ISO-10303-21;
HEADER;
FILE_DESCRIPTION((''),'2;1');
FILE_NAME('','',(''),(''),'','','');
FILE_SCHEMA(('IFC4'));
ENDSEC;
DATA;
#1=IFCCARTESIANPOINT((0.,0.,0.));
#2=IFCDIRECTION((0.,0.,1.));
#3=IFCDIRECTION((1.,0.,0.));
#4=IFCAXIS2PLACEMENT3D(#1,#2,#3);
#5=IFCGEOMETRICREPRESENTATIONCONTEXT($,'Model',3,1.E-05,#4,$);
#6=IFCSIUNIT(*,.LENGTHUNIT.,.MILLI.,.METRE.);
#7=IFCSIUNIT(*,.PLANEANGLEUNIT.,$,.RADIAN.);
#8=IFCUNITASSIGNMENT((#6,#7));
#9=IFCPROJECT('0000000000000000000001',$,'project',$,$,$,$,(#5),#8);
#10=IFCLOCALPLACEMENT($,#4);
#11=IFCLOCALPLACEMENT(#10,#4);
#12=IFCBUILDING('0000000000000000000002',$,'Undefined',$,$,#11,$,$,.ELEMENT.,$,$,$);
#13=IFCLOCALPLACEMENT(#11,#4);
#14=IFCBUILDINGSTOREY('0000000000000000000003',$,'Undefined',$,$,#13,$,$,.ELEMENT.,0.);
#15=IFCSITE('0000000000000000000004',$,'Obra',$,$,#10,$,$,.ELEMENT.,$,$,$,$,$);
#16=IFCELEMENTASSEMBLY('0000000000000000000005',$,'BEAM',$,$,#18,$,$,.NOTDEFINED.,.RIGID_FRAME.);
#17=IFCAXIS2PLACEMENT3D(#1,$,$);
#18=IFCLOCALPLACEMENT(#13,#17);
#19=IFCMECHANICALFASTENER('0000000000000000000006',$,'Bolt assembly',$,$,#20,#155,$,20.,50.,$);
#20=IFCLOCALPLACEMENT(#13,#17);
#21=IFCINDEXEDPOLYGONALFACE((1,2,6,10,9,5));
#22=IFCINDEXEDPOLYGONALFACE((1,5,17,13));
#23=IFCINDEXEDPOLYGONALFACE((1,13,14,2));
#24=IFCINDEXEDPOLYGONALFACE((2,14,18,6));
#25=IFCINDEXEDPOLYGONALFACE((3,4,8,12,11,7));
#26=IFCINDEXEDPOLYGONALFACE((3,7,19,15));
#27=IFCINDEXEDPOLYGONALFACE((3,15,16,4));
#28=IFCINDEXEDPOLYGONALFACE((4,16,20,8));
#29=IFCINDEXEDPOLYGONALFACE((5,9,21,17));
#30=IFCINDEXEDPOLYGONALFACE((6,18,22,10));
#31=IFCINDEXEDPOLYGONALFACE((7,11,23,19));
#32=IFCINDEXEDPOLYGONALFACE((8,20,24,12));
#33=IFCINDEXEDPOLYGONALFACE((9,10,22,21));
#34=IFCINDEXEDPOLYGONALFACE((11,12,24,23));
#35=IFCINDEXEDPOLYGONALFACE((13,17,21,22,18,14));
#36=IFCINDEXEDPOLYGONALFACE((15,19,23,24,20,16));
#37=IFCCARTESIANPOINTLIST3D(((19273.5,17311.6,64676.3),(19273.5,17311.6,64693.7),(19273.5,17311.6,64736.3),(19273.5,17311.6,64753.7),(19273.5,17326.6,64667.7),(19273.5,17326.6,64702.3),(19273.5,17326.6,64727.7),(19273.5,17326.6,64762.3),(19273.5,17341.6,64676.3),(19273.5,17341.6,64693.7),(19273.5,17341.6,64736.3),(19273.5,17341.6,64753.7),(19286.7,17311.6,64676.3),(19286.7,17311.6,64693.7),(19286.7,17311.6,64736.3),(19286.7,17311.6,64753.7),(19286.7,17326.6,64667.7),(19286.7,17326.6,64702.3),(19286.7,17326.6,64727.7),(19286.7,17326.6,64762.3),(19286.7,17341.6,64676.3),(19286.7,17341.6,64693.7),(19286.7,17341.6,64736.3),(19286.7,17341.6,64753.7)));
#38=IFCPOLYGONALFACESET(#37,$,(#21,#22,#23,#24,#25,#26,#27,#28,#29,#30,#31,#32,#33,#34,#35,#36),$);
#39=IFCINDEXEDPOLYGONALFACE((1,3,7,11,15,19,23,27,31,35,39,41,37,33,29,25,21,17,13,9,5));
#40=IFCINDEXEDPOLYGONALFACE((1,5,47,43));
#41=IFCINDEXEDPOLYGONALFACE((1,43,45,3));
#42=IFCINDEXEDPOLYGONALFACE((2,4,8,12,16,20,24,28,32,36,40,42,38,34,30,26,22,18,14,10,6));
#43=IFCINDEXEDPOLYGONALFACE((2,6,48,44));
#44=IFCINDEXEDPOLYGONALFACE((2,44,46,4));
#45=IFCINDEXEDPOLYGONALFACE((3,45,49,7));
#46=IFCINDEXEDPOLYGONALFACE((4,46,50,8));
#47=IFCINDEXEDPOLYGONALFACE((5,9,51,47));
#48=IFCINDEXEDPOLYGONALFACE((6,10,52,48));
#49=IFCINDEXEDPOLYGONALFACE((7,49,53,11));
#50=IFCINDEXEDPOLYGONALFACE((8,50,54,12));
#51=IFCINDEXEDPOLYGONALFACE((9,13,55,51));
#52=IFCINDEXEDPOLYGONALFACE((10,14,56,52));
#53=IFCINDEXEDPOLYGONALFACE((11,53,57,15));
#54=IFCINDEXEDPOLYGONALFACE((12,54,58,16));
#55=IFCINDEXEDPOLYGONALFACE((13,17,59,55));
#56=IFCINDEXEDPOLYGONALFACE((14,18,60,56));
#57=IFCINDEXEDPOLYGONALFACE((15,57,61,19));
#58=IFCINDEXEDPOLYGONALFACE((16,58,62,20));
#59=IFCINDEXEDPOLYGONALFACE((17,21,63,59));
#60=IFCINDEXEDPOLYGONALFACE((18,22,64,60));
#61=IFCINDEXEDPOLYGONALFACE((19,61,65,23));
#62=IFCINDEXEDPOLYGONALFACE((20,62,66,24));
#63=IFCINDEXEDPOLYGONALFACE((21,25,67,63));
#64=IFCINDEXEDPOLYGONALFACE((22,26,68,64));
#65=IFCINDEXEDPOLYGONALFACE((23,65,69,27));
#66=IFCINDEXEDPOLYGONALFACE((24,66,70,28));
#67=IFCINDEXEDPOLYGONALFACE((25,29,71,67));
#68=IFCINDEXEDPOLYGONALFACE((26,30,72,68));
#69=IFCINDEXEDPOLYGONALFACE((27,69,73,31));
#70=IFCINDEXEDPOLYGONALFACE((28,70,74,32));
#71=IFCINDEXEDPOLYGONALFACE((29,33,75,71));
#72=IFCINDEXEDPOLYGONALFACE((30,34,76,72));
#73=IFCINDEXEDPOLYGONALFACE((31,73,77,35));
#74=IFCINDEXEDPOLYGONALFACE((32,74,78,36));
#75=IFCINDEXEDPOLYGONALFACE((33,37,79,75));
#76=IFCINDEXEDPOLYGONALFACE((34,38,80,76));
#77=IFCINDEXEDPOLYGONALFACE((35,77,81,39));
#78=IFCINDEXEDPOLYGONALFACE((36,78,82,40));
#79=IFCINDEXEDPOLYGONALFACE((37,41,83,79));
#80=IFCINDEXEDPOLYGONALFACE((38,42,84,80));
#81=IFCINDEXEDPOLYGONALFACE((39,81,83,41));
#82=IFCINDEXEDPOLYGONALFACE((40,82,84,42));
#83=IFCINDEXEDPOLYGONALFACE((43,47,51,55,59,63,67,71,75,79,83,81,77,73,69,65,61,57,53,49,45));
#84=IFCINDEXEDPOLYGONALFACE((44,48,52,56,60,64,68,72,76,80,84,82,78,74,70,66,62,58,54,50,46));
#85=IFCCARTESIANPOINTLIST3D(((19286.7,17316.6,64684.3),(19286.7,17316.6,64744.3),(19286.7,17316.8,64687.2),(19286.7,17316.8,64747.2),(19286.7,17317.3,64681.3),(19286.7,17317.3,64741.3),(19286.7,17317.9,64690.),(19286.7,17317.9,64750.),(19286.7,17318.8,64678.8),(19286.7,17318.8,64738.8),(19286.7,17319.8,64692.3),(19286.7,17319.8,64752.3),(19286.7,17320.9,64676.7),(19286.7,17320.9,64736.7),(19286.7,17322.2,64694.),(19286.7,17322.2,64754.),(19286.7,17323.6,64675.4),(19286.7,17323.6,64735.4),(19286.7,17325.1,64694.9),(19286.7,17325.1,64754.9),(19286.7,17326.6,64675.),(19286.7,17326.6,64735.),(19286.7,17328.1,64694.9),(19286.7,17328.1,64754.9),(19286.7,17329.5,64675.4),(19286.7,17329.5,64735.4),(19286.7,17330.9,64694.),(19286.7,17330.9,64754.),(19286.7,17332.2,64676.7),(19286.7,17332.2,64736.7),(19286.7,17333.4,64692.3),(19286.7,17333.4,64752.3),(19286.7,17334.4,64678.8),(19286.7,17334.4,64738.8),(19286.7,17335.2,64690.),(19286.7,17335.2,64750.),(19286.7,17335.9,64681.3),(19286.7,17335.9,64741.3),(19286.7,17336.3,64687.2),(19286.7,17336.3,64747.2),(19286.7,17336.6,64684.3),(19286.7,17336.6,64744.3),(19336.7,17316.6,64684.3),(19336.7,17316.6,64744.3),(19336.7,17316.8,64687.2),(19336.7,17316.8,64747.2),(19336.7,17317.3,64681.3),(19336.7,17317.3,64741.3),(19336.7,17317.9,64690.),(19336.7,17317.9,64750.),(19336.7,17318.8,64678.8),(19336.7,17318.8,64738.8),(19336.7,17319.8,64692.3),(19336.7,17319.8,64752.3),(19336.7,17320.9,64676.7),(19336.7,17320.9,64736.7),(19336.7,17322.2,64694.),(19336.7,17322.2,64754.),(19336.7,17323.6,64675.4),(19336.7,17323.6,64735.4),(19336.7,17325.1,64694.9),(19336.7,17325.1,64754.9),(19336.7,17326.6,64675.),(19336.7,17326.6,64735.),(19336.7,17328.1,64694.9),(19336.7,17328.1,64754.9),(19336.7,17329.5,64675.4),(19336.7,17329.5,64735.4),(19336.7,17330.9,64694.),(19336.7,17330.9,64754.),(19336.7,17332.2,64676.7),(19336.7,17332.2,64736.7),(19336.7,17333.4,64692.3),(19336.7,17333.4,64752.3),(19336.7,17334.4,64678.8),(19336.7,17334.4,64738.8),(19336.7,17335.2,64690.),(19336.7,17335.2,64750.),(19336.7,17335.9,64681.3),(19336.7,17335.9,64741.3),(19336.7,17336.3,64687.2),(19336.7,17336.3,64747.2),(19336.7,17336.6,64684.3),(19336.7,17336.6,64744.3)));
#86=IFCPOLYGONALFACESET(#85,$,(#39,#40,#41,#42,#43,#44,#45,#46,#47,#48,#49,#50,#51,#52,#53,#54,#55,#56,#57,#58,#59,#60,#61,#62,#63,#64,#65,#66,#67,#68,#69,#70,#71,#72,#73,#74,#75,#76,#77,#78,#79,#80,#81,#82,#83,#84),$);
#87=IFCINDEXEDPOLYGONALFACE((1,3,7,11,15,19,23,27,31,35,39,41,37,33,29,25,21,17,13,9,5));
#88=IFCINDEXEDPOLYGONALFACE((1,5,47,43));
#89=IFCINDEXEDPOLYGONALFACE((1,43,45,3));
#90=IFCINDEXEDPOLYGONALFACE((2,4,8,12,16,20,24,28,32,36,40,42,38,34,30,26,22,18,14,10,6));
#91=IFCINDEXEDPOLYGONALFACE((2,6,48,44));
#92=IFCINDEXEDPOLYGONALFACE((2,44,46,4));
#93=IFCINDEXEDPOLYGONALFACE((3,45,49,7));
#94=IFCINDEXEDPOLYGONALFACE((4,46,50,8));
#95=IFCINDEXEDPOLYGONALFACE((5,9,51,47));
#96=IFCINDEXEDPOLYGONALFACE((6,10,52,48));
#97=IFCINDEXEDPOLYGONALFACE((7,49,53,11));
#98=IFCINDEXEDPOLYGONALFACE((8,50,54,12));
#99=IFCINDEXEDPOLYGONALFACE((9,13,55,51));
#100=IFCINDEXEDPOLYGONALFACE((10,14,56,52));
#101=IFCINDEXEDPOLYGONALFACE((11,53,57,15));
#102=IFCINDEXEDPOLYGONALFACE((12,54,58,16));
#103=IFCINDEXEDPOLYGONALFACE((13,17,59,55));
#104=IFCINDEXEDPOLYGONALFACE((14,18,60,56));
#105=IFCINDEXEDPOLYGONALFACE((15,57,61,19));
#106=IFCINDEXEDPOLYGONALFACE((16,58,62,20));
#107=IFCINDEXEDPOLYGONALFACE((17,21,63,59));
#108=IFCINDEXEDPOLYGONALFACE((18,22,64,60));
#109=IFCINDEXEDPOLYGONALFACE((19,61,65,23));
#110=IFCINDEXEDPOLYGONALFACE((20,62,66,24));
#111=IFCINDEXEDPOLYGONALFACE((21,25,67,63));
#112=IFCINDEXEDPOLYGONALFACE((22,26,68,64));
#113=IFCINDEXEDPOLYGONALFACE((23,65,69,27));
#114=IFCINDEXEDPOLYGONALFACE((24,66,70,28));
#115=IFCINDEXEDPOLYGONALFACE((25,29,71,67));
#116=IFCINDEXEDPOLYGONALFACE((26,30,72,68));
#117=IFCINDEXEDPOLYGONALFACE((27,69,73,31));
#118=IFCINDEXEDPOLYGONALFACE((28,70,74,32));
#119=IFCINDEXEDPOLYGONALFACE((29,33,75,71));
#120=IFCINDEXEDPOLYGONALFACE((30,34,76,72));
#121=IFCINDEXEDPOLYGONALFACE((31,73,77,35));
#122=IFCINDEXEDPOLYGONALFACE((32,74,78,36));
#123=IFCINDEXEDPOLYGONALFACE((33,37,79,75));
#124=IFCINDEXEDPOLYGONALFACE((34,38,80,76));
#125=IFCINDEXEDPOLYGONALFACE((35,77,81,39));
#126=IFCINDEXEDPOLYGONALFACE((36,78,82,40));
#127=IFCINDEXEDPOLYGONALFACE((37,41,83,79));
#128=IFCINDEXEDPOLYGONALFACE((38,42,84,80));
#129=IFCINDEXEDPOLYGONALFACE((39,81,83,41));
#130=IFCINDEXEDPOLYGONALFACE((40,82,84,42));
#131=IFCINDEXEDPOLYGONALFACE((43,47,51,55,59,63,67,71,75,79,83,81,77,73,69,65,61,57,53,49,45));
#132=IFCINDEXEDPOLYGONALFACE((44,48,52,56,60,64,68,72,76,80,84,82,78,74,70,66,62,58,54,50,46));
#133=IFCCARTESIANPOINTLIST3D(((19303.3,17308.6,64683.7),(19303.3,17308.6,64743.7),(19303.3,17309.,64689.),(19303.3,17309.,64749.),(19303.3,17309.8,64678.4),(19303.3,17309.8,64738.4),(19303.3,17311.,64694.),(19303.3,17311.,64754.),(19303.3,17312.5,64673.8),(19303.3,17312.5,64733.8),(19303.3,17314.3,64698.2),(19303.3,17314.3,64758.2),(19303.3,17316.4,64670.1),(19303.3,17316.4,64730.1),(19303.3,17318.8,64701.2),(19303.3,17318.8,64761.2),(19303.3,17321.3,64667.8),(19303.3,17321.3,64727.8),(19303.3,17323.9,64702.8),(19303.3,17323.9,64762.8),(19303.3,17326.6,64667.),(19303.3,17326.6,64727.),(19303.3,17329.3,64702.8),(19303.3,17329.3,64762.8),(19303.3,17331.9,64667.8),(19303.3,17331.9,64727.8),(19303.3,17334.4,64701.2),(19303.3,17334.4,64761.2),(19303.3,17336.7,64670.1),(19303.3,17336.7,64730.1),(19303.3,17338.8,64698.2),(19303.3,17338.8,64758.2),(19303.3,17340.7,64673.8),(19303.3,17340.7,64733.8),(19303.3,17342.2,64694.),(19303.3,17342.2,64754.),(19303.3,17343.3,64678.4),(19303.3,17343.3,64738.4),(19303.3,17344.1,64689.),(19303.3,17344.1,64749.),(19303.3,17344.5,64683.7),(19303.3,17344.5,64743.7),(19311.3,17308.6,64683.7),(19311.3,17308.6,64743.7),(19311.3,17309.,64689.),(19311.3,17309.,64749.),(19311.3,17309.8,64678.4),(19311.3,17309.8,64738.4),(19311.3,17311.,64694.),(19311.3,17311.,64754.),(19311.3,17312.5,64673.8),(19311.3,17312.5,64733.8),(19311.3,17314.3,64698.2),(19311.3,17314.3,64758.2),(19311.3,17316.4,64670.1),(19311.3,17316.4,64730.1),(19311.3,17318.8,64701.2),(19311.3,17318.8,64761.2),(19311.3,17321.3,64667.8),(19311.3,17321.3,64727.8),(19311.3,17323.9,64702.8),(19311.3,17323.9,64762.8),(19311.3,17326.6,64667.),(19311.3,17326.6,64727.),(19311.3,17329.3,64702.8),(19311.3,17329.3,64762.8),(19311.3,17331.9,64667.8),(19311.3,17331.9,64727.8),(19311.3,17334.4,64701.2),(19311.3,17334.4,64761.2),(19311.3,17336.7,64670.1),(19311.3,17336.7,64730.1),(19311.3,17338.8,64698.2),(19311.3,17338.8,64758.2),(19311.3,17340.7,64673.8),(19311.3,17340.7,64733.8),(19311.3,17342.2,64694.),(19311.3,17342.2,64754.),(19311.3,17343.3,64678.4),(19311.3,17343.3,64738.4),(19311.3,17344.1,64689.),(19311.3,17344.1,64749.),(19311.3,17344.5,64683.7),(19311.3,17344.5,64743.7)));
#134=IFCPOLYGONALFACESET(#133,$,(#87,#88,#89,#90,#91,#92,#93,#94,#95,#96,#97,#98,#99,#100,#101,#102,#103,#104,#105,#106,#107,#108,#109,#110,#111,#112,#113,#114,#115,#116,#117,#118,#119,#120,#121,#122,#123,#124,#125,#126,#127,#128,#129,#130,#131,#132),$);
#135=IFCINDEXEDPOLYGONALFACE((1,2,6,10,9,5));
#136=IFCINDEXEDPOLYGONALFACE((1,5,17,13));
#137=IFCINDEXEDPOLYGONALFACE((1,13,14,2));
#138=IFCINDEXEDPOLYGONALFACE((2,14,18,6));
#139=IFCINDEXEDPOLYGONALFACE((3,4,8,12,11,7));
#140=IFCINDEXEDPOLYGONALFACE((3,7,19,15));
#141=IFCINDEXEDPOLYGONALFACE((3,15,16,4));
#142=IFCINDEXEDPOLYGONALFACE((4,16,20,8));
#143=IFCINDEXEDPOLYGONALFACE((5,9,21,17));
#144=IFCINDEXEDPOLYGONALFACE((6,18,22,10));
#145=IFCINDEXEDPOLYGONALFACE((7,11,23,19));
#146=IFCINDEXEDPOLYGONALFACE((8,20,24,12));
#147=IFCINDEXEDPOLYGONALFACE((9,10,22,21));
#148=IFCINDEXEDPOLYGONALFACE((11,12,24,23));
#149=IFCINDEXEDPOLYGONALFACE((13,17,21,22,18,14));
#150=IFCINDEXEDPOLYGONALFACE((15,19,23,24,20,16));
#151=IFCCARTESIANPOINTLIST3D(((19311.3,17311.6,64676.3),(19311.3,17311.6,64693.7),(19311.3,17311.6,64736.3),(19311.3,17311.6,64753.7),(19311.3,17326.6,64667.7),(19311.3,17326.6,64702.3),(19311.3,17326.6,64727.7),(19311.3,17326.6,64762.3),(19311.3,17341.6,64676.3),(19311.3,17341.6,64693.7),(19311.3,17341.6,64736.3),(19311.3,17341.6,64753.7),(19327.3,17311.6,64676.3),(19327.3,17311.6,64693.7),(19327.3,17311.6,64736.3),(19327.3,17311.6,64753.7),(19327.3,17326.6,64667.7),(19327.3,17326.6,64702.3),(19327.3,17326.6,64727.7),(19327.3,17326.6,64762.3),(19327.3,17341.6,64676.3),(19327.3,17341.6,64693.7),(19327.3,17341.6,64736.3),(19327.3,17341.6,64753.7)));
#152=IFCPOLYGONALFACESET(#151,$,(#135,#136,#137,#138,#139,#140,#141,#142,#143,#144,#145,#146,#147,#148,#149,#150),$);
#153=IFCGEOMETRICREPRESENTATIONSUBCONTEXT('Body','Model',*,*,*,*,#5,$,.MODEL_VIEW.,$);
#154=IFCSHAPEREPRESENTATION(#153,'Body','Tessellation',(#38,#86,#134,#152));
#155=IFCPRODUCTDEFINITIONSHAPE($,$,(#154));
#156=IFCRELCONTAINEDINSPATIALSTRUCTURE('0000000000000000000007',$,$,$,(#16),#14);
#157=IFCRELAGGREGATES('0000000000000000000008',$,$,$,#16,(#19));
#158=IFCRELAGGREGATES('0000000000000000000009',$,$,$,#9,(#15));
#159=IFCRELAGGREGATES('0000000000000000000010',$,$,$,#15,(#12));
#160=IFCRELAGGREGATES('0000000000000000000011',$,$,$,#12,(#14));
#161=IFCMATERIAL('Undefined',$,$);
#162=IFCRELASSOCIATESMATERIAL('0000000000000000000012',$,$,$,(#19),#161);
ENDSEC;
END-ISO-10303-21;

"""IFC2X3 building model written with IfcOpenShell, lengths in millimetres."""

from ifc_helpers import new_model, si_unit, frame, origin_with_axes, origin_2d_with_axis, place, context, subcontext, project, spatial, polyline, circle, outline, extrude, source, transform, mapped, material, element, aggregate, save


model = new_model("IFC2X3")

# Units and contexts
model_context = context("Model", 3, precision=1e-05, world=origin_with_axes())
body_context = subcontext(model_context, "Body", "Model", "MODEL_VIEW")
ifc_project = project(units=[si_unit("LENGTHUNIT", "METRE", prefix="MILLI"), si_unit("PLANEANGLEUNIT", "RADIAN")], contexts=[model_context])

# Site, building, storey
site_placement = place(None, origin_with_axes())
site = spatial("IfcSite", under=ifc_project, at=site_placement, Name="Obra", CompositionType="ELEMENT")
building_placement = place(site_placement, origin_with_axes())
building = spatial("IfcBuilding", under=site, at=building_placement, Name="Undefined", CompositionType="ELEMENT")
storey_placement = place(building_placement, origin_with_axes())
storey = spatial("IfcBuildingStorey", under=building, at=storey_placement, Name="Undefined", CompositionType="ELEMENT", Elevation=0.0)

# Shared definitions
ifc_material = material(Name="Undefined")
shared_shape_1 = source(origin_with_axes(), body_context, "Body", "SweptSolid", [
    extrude(outline(polyline([(17.3, 0.0), (8.7, 15.0), (-8.7, 15.0), (-17.3, 0.0), (-8.7, -15.0), (8.7, -15.0), (17.3, 0.0)])), frame((0.0, -26.5, 0.0), z_axis=(0.0, 1.0, 0.0), x_axis=(1.0, 0.0, 0.0)), (0.0, 0.0, 1.0), 13.2),
    extrude(circle(Radius=10.0, at=origin_2d_with_axis()), frame((0.0, -13.3, 0.0), z_axis=(0.0, 1.0, 0.0), x_axis=(1.0, 0.0, 0.0)), (0.0, 0.0, 1.0), 50.0),
    extrude(circle(Radius=18.0, at=origin_2d_with_axis()), frame((0.0, 3.3, 0.0), z_axis=(0.0, 1.0, 0.0), x_axis=(1.0, 0.0, 0.0)), (0.0, 0.0, 1.0), 8.0),
    extrude(outline(polyline([(17.3, 0.0), (8.7, 15.0), (-8.7, 15.0), (-17.3, 0.0), (-8.7, -15.0), (8.7, -15.0), (17.3, 0.0)])), frame((0.0, 11.3, 0.0), z_axis=(0.0, 1.0, 0.0), x_axis=(1.0, 0.0, 0.0)), (0.0, 0.0, 1.0), 16.0),
])

# Element assembly, mechanical fastener
assembly_1_placement = place(storey_placement, origin_with_axes())
assembly_1 = element("IfcElementAssembly", 1, at=assembly_1_placement, inside=storey, Name="BEAM", AssemblyPlace="NOTDEFINED", PredefinedType="RIGID_FRAME")
mechanical_fastener_1_placement = place(assembly_1_placement, frame((19300.0, 17366.6, 64850.0), z_axis=(0.0, -1.0, 0.0), x_axis=(0.0, 0.0, -1.0)))
mechanical_fastener_1 = element("IfcMechanicalFastener", 2, at=mechanical_fastener_1_placement, material=ifc_material, Name="Bolt assembly", NominalDiameter=20.0, NominalLength=50.0, context=body_context, shape_type="MappedRepresentation", body=[
    mapped(shared_shape_1, transform((105.0, 0.0, 40.0))),
    mapped(shared_shape_1, transform((165.0, 0.0, 40.0))),
])

aggregate(assembly_1, [mechanical_fastener_1])

save(model, "model.ifc")
